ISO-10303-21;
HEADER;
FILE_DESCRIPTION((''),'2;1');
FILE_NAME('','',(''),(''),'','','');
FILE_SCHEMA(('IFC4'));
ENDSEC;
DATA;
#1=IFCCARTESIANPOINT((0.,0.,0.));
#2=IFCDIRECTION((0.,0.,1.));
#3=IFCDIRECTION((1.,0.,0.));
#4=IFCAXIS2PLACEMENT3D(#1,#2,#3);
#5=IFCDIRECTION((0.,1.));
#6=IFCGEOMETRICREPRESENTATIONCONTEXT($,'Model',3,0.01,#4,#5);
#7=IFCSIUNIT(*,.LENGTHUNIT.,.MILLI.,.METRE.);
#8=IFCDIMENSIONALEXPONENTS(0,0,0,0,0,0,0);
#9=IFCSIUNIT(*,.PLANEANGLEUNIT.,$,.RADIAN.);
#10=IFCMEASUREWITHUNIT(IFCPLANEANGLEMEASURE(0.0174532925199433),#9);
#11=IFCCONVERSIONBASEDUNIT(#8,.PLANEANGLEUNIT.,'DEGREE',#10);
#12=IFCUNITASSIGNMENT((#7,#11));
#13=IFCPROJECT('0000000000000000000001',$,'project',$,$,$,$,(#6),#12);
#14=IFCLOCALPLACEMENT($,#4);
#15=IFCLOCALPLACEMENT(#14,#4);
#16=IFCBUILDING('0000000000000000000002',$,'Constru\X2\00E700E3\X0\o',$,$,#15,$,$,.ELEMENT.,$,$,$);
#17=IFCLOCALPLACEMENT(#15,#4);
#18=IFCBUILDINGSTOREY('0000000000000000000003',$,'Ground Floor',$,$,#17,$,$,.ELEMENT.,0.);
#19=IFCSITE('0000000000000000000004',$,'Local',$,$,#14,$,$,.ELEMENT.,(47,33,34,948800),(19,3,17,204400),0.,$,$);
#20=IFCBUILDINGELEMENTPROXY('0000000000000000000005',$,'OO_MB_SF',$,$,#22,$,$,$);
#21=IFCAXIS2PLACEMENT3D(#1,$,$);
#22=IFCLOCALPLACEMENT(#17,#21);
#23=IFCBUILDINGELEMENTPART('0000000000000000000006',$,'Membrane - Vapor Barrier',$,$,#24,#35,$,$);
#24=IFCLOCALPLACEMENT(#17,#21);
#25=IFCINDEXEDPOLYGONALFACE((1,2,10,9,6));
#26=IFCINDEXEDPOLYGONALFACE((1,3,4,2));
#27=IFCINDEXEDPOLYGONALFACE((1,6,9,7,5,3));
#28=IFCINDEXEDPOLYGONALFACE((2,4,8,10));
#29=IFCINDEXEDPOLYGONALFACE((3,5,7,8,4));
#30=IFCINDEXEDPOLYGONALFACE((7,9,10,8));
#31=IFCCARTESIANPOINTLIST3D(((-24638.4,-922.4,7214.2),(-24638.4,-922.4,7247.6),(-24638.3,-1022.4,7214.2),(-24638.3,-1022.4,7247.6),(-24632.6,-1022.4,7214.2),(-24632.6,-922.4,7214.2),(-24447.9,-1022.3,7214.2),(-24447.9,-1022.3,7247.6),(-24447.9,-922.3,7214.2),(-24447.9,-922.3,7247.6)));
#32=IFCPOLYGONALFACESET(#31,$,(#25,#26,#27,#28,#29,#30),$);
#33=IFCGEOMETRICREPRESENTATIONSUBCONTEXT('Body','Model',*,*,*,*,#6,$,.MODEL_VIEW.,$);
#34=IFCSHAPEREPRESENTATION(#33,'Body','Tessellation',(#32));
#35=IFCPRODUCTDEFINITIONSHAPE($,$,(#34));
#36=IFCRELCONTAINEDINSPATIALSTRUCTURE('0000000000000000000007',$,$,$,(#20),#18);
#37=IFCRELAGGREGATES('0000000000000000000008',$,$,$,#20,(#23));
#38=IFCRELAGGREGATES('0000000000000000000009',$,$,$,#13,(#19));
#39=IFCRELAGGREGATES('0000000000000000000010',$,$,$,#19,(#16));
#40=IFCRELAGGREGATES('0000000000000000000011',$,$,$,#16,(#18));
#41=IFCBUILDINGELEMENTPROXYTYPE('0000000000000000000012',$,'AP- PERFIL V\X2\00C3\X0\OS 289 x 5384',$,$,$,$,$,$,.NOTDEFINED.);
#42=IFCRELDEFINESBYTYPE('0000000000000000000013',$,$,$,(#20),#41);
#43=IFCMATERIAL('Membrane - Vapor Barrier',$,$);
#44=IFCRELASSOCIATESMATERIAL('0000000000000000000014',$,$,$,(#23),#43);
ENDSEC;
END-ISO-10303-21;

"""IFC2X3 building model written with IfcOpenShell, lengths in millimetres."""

from ifc_helpers import new_model, entity, si_unit, converted_unit, direction, frame, origin_with_axes, place, context, subcontext, project, spatial, polyline, outline, extrude, material, type_object, element, aggregate, save


model = new_model("IFC2X3")

# Units and contexts
model_context = context("Model", 3, precision=0.01, world=origin_with_axes(), true_north=direction((0.0, 1.0)))
body_context = subcontext(model_context, "Body", "Model", "MODEL_VIEW")
ifc_project = project(units=[si_unit("LENGTHUNIT", "METRE", prefix="MILLI"), converted_unit("PLANEANGLEUNIT", "DEGREE", entity("IfcPlaneAngleMeasure", 0.0174532925199433), si_unit("PLANEANGLEUNIT", "RADIAN"), dimensions=[0, 0, 0, 0, 0, 0, 0])], contexts=[model_context])

# Site, building, storey
site_placement = place(None, origin_with_axes())
site = spatial("IfcSite", under=ifc_project, at=site_placement, Name="Local", CompositionType="ELEMENT", RefLatitude=(47, 33, 34, 948800), RefLongitude=(19, 3, 17, 204400), RefElevation=0.0)
building_placement = place(site_placement, origin_with_axes())
building = spatial("IfcBuilding", under=site, at=building_placement, Name="Construção", CompositionType="ELEMENT")
storey_placement = place(building_placement, origin_with_axes())
storey = spatial("IfcBuildingStorey", under=building, at=storey_placement, Name="Ground Floor", CompositionType="ELEMENT", Elevation=0.0)

# Building element proxy, building element part
building_element_proxy_type = type_object("IfcBuildingElementProxyType", Name="AP- PERFIL VÃOS 289 x 5384", PredefinedType="NOTDEFINED")
proxy_1_placement = place(storey_placement, frame((-24447.9, -922.3, 7247.6), z_axis=(0.0, 0.0, 1.0), x_axis=(-1.0, -0.000322, 0.0)))
proxy_1 = element("IfcBuildingElementProxy", 1, at=proxy_1_placement, inside=storey, type_object=building_element_proxy_type, Name="OO_MB_SF")
ifc_material = material(Name="Membrane - Vapor Barrier")
building_element_part_1_placement = place(proxy_1_placement, origin_with_axes())
building_element_part_1 = element("IfcBuildingElementPart", 2, at=building_element_part_1_placement, material=ifc_material, Name="Membrane - Vapor Barrier", context=body_context, shape_type="SweptSolid", body=[
    extrude(outline(polyline([(190.4, 0.0), (0.0, 0.0), (0.0, -33.3), (184.7, -33.3), (190.4, -33.3), (190.4, 0.0)])), frame((0.0, 100.0, 0.0), z_axis=(0.0, -1.0, 0.0), x_axis=(1.0, 0.0, 0.0)), (0.0, 0.0, 1.0), 100.0),
])
aggregate(proxy_1, [building_element_part_1])

save(model, "model.ifc")
